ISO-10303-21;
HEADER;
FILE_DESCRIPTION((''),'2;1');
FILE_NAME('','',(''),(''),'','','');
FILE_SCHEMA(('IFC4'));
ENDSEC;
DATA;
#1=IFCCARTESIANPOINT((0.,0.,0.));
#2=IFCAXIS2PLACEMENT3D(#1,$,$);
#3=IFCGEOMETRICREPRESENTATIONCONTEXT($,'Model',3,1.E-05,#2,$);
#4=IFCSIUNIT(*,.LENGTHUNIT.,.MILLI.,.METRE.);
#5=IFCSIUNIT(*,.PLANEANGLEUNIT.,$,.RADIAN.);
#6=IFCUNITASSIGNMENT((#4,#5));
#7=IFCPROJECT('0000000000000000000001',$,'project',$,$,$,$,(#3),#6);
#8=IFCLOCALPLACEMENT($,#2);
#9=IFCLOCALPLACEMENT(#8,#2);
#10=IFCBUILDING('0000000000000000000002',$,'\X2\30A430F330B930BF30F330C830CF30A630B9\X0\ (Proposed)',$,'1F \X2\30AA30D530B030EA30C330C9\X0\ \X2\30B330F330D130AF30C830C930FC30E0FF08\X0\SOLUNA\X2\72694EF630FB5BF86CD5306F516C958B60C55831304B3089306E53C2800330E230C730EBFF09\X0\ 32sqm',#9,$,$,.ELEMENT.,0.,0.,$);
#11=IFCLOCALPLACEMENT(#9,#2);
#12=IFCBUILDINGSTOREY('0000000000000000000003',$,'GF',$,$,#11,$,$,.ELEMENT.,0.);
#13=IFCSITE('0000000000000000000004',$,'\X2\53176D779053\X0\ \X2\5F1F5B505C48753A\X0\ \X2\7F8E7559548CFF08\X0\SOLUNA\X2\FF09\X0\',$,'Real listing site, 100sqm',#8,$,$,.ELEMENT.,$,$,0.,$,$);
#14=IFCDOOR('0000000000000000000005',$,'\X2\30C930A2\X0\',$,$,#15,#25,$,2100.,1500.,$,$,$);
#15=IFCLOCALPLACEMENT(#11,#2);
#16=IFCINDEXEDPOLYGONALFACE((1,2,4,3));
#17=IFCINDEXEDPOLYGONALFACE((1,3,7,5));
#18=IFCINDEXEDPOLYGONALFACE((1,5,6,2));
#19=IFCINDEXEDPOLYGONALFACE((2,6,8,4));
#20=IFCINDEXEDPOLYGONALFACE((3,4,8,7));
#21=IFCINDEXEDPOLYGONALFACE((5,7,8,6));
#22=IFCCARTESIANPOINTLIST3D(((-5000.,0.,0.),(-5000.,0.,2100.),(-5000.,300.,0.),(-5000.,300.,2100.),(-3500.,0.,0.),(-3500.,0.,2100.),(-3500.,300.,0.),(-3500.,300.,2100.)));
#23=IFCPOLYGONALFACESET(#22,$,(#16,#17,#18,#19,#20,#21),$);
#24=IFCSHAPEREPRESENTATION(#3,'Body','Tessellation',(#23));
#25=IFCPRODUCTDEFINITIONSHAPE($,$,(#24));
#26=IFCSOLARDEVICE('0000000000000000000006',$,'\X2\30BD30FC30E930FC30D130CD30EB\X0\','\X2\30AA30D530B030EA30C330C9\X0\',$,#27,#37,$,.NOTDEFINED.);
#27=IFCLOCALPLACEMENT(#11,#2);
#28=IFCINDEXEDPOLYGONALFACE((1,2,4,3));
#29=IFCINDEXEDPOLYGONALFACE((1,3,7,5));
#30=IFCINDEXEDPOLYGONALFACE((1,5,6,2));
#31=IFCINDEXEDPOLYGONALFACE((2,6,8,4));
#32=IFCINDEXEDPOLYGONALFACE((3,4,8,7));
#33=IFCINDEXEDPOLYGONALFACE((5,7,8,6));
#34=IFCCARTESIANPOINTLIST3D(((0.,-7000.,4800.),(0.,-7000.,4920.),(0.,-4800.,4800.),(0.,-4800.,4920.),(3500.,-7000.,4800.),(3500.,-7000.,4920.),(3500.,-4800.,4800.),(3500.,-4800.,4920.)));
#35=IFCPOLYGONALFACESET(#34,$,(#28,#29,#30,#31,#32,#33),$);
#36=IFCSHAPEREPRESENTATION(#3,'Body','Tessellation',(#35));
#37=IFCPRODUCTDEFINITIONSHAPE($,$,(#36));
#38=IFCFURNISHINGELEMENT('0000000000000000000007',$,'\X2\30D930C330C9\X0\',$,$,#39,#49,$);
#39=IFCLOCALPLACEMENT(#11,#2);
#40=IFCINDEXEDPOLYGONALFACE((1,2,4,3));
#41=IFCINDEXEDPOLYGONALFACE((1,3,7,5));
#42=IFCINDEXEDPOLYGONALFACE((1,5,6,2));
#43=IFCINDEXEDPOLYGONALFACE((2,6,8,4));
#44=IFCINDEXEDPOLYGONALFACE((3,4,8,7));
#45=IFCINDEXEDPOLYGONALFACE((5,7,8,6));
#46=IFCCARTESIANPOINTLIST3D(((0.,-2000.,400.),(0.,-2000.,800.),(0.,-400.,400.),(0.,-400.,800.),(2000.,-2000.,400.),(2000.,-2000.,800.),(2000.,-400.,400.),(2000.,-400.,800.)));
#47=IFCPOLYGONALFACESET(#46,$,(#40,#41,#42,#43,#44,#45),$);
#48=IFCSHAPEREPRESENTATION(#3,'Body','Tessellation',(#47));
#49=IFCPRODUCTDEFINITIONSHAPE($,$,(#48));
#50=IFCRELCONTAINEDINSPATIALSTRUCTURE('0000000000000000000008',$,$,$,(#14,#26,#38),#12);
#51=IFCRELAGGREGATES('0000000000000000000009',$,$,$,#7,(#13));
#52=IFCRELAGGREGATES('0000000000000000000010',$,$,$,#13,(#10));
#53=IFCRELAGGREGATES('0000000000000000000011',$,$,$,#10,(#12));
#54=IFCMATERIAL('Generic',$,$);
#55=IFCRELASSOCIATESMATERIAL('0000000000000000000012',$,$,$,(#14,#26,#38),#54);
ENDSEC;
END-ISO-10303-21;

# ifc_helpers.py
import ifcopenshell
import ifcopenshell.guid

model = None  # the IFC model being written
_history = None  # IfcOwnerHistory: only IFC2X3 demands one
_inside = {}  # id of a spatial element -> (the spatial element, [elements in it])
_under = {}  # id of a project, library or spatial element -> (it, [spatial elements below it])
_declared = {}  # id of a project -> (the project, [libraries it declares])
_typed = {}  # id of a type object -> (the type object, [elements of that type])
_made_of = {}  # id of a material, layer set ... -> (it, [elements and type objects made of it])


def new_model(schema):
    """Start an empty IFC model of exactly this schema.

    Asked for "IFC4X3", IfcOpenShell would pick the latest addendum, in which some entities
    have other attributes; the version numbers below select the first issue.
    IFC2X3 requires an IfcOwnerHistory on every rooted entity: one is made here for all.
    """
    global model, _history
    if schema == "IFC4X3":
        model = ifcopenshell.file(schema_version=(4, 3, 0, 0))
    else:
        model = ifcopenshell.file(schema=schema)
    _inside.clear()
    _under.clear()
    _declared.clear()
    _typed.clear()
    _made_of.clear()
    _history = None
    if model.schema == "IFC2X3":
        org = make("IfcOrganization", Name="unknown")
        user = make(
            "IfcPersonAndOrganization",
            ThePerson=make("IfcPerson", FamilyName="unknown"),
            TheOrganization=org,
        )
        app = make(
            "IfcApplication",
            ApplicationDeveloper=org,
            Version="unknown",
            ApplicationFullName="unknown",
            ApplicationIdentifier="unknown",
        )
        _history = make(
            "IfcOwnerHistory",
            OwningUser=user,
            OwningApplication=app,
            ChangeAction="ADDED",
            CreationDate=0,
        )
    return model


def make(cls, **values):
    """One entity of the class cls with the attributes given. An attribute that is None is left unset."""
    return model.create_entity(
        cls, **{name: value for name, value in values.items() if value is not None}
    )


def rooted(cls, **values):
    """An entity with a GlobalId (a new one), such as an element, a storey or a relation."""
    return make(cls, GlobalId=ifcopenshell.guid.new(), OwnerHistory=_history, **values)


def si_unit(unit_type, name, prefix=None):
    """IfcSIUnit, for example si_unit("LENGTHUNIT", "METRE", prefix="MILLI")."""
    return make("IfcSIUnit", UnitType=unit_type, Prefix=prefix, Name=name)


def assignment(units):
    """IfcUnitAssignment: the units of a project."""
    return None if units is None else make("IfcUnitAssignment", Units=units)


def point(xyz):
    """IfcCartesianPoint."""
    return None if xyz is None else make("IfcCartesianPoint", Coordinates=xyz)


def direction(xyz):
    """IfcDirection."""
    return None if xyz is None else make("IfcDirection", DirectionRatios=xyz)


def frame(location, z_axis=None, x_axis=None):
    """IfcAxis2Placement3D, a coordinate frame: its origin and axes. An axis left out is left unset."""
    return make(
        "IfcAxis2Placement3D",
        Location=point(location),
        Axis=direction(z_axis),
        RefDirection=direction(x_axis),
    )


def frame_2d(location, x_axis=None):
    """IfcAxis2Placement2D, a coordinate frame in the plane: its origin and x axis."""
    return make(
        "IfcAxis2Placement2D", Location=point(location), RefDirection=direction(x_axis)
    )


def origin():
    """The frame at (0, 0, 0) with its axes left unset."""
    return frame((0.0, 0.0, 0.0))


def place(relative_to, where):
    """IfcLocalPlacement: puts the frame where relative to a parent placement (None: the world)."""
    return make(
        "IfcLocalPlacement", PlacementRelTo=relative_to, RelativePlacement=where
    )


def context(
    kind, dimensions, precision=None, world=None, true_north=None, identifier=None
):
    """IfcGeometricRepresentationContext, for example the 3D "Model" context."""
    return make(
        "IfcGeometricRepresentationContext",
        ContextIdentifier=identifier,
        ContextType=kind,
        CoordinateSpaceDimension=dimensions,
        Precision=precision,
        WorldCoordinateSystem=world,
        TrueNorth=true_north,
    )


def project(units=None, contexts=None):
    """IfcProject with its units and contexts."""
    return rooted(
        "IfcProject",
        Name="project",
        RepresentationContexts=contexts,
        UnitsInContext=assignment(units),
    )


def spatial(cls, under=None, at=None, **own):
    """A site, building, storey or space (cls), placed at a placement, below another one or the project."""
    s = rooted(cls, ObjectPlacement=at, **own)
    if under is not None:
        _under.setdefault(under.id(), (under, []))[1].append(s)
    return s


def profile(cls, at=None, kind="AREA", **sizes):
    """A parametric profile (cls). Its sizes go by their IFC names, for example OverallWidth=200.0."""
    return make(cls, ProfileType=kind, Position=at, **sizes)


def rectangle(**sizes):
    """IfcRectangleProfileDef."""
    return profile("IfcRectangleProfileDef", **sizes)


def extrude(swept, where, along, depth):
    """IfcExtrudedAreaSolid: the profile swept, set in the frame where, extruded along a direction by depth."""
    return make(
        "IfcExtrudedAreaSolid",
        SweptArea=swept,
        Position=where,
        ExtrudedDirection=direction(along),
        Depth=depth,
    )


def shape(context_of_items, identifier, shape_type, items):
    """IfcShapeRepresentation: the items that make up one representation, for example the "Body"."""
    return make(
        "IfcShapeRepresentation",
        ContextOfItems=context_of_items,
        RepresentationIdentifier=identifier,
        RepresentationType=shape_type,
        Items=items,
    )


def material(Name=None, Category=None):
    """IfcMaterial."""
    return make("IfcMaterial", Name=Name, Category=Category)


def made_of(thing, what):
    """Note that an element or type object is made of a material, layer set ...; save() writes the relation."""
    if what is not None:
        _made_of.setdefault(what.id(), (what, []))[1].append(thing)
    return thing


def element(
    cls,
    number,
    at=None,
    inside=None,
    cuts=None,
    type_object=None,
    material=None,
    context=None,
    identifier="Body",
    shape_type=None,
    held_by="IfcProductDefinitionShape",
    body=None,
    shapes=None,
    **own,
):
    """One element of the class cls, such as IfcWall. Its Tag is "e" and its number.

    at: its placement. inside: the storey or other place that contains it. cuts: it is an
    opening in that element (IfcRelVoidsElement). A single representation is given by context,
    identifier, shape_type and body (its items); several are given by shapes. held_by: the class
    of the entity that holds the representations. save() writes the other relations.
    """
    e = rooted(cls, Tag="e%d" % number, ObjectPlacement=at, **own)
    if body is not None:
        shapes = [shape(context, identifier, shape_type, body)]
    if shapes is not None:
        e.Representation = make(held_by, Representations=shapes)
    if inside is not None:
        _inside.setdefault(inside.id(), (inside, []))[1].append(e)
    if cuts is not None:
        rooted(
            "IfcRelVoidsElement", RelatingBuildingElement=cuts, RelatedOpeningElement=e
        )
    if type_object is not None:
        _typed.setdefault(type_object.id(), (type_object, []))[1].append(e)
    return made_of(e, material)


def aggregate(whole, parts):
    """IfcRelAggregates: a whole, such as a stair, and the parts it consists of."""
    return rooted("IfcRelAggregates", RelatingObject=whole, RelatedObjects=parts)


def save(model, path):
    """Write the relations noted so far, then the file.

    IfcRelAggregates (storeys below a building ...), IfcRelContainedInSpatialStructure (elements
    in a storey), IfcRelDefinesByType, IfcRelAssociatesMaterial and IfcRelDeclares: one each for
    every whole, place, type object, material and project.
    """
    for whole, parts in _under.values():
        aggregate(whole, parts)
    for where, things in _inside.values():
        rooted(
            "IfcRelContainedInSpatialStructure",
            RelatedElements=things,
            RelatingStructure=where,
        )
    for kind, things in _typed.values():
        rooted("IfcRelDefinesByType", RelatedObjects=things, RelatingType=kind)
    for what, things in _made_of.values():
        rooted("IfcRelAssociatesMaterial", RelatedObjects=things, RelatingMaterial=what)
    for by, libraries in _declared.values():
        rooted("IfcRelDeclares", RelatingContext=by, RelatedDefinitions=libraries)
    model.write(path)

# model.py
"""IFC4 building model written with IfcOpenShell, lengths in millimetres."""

from ifc_helpers import new_model, si_unit, frame, frame_2d, origin, place, context, project, spatial, rectangle, extrude, material, element, save


model = new_model("IFC4")

# Units and contexts
model_context = context("Model", 3, precision=1e-05, world=origin())
ifc_project = project(units=[si_unit("LENGTHUNIT", "METRE", prefix="MILLI"), si_unit("PLANEANGLEUNIT", "RADIAN")], contexts=[model_context])

# Site, building, storey
site_placement = place(None, origin())
site = spatial("IfcSite", under=ifc_project, at=site_placement, Name="北海道 弟子屈町 美留和（SOLUNA）", ObjectType="Real listing site, 100sqm", CompositionType="ELEMENT", RefElevation=0.0)
building_placement = place(site_placement, origin())
building = spatial("IfcBuilding", under=site, at=building_placement, Name="インスタントハウス (Proposed)", ObjectType="1F オフグリッド コンパクトドーム（SOLUNA物件・寸法は公開情報からの参考モデル） 32sqm", CompositionType="ELEMENT", ElevationOfRefHeight=0.0, ElevationOfTerrain=0.0)
storey_placement = place(building_placement, origin())
storey = spatial("IfcBuildingStorey", under=building, at=storey_placement, Name="GF", CompositionType="ELEMENT", Elevation=0.0)

# Shared definitions
ifc_material_1 = material(Name="Generic")

# Door
door_placement = place(storey_placement, frame((-2500.0, 0.0, 0.0)))
element("IfcDoor", 1, at=door_placement, inside=storey, material=ifc_material_1, Name="ドア", OverallHeight=2100.0, OverallWidth=1500.0, context=model_context, shape_type="SweptSolid", body=[
    extrude(rectangle(XDim=1500.0, YDim=300.0, at=frame_2d((750.0, 150.0))), frame((-2500.0, 0.0, 0.0)), (0.0, 0.0, 1.0), 2100.0),
])

# Solar device
solar_device_placement = place(storey_placement, frame((0.0, -3500.0, 2400.0)))
element("IfcSolarDevice", 2, at=solar_device_placement, inside=storey, material=ifc_material_1, Name="ソーラーパネル", Description="オフグリッド", PredefinedType="NOTDEFINED", context=model_context, shape_type="SweptSolid", body=[
    extrude(rectangle(XDim=3500.0, YDim=2200.0, at=frame_2d((1750.0, 1100.0))), frame((0.0, -3500.0, 2400.0)), (0.0, 0.0, 1.0), 120.0),
])

# Furnishing element
furnishing_1_placement = place(storey_placement, frame((0.0, -1000.0, 200.0)))
element("IfcFurnishingElement", 3, at=furnishing_1_placement, inside=storey, material=ifc_material_1, Name="ベッド", context=model_context, shape_type="SweptSolid", body=[
    extrude(rectangle(XDim=2000.0, YDim=1600.0, at=frame_2d((1000.0, 800.0))), frame((0.0, -1000.0, 200.0)), (0.0, 0.0, 1.0), 400.0),
])

save(model, "model.ifc")
